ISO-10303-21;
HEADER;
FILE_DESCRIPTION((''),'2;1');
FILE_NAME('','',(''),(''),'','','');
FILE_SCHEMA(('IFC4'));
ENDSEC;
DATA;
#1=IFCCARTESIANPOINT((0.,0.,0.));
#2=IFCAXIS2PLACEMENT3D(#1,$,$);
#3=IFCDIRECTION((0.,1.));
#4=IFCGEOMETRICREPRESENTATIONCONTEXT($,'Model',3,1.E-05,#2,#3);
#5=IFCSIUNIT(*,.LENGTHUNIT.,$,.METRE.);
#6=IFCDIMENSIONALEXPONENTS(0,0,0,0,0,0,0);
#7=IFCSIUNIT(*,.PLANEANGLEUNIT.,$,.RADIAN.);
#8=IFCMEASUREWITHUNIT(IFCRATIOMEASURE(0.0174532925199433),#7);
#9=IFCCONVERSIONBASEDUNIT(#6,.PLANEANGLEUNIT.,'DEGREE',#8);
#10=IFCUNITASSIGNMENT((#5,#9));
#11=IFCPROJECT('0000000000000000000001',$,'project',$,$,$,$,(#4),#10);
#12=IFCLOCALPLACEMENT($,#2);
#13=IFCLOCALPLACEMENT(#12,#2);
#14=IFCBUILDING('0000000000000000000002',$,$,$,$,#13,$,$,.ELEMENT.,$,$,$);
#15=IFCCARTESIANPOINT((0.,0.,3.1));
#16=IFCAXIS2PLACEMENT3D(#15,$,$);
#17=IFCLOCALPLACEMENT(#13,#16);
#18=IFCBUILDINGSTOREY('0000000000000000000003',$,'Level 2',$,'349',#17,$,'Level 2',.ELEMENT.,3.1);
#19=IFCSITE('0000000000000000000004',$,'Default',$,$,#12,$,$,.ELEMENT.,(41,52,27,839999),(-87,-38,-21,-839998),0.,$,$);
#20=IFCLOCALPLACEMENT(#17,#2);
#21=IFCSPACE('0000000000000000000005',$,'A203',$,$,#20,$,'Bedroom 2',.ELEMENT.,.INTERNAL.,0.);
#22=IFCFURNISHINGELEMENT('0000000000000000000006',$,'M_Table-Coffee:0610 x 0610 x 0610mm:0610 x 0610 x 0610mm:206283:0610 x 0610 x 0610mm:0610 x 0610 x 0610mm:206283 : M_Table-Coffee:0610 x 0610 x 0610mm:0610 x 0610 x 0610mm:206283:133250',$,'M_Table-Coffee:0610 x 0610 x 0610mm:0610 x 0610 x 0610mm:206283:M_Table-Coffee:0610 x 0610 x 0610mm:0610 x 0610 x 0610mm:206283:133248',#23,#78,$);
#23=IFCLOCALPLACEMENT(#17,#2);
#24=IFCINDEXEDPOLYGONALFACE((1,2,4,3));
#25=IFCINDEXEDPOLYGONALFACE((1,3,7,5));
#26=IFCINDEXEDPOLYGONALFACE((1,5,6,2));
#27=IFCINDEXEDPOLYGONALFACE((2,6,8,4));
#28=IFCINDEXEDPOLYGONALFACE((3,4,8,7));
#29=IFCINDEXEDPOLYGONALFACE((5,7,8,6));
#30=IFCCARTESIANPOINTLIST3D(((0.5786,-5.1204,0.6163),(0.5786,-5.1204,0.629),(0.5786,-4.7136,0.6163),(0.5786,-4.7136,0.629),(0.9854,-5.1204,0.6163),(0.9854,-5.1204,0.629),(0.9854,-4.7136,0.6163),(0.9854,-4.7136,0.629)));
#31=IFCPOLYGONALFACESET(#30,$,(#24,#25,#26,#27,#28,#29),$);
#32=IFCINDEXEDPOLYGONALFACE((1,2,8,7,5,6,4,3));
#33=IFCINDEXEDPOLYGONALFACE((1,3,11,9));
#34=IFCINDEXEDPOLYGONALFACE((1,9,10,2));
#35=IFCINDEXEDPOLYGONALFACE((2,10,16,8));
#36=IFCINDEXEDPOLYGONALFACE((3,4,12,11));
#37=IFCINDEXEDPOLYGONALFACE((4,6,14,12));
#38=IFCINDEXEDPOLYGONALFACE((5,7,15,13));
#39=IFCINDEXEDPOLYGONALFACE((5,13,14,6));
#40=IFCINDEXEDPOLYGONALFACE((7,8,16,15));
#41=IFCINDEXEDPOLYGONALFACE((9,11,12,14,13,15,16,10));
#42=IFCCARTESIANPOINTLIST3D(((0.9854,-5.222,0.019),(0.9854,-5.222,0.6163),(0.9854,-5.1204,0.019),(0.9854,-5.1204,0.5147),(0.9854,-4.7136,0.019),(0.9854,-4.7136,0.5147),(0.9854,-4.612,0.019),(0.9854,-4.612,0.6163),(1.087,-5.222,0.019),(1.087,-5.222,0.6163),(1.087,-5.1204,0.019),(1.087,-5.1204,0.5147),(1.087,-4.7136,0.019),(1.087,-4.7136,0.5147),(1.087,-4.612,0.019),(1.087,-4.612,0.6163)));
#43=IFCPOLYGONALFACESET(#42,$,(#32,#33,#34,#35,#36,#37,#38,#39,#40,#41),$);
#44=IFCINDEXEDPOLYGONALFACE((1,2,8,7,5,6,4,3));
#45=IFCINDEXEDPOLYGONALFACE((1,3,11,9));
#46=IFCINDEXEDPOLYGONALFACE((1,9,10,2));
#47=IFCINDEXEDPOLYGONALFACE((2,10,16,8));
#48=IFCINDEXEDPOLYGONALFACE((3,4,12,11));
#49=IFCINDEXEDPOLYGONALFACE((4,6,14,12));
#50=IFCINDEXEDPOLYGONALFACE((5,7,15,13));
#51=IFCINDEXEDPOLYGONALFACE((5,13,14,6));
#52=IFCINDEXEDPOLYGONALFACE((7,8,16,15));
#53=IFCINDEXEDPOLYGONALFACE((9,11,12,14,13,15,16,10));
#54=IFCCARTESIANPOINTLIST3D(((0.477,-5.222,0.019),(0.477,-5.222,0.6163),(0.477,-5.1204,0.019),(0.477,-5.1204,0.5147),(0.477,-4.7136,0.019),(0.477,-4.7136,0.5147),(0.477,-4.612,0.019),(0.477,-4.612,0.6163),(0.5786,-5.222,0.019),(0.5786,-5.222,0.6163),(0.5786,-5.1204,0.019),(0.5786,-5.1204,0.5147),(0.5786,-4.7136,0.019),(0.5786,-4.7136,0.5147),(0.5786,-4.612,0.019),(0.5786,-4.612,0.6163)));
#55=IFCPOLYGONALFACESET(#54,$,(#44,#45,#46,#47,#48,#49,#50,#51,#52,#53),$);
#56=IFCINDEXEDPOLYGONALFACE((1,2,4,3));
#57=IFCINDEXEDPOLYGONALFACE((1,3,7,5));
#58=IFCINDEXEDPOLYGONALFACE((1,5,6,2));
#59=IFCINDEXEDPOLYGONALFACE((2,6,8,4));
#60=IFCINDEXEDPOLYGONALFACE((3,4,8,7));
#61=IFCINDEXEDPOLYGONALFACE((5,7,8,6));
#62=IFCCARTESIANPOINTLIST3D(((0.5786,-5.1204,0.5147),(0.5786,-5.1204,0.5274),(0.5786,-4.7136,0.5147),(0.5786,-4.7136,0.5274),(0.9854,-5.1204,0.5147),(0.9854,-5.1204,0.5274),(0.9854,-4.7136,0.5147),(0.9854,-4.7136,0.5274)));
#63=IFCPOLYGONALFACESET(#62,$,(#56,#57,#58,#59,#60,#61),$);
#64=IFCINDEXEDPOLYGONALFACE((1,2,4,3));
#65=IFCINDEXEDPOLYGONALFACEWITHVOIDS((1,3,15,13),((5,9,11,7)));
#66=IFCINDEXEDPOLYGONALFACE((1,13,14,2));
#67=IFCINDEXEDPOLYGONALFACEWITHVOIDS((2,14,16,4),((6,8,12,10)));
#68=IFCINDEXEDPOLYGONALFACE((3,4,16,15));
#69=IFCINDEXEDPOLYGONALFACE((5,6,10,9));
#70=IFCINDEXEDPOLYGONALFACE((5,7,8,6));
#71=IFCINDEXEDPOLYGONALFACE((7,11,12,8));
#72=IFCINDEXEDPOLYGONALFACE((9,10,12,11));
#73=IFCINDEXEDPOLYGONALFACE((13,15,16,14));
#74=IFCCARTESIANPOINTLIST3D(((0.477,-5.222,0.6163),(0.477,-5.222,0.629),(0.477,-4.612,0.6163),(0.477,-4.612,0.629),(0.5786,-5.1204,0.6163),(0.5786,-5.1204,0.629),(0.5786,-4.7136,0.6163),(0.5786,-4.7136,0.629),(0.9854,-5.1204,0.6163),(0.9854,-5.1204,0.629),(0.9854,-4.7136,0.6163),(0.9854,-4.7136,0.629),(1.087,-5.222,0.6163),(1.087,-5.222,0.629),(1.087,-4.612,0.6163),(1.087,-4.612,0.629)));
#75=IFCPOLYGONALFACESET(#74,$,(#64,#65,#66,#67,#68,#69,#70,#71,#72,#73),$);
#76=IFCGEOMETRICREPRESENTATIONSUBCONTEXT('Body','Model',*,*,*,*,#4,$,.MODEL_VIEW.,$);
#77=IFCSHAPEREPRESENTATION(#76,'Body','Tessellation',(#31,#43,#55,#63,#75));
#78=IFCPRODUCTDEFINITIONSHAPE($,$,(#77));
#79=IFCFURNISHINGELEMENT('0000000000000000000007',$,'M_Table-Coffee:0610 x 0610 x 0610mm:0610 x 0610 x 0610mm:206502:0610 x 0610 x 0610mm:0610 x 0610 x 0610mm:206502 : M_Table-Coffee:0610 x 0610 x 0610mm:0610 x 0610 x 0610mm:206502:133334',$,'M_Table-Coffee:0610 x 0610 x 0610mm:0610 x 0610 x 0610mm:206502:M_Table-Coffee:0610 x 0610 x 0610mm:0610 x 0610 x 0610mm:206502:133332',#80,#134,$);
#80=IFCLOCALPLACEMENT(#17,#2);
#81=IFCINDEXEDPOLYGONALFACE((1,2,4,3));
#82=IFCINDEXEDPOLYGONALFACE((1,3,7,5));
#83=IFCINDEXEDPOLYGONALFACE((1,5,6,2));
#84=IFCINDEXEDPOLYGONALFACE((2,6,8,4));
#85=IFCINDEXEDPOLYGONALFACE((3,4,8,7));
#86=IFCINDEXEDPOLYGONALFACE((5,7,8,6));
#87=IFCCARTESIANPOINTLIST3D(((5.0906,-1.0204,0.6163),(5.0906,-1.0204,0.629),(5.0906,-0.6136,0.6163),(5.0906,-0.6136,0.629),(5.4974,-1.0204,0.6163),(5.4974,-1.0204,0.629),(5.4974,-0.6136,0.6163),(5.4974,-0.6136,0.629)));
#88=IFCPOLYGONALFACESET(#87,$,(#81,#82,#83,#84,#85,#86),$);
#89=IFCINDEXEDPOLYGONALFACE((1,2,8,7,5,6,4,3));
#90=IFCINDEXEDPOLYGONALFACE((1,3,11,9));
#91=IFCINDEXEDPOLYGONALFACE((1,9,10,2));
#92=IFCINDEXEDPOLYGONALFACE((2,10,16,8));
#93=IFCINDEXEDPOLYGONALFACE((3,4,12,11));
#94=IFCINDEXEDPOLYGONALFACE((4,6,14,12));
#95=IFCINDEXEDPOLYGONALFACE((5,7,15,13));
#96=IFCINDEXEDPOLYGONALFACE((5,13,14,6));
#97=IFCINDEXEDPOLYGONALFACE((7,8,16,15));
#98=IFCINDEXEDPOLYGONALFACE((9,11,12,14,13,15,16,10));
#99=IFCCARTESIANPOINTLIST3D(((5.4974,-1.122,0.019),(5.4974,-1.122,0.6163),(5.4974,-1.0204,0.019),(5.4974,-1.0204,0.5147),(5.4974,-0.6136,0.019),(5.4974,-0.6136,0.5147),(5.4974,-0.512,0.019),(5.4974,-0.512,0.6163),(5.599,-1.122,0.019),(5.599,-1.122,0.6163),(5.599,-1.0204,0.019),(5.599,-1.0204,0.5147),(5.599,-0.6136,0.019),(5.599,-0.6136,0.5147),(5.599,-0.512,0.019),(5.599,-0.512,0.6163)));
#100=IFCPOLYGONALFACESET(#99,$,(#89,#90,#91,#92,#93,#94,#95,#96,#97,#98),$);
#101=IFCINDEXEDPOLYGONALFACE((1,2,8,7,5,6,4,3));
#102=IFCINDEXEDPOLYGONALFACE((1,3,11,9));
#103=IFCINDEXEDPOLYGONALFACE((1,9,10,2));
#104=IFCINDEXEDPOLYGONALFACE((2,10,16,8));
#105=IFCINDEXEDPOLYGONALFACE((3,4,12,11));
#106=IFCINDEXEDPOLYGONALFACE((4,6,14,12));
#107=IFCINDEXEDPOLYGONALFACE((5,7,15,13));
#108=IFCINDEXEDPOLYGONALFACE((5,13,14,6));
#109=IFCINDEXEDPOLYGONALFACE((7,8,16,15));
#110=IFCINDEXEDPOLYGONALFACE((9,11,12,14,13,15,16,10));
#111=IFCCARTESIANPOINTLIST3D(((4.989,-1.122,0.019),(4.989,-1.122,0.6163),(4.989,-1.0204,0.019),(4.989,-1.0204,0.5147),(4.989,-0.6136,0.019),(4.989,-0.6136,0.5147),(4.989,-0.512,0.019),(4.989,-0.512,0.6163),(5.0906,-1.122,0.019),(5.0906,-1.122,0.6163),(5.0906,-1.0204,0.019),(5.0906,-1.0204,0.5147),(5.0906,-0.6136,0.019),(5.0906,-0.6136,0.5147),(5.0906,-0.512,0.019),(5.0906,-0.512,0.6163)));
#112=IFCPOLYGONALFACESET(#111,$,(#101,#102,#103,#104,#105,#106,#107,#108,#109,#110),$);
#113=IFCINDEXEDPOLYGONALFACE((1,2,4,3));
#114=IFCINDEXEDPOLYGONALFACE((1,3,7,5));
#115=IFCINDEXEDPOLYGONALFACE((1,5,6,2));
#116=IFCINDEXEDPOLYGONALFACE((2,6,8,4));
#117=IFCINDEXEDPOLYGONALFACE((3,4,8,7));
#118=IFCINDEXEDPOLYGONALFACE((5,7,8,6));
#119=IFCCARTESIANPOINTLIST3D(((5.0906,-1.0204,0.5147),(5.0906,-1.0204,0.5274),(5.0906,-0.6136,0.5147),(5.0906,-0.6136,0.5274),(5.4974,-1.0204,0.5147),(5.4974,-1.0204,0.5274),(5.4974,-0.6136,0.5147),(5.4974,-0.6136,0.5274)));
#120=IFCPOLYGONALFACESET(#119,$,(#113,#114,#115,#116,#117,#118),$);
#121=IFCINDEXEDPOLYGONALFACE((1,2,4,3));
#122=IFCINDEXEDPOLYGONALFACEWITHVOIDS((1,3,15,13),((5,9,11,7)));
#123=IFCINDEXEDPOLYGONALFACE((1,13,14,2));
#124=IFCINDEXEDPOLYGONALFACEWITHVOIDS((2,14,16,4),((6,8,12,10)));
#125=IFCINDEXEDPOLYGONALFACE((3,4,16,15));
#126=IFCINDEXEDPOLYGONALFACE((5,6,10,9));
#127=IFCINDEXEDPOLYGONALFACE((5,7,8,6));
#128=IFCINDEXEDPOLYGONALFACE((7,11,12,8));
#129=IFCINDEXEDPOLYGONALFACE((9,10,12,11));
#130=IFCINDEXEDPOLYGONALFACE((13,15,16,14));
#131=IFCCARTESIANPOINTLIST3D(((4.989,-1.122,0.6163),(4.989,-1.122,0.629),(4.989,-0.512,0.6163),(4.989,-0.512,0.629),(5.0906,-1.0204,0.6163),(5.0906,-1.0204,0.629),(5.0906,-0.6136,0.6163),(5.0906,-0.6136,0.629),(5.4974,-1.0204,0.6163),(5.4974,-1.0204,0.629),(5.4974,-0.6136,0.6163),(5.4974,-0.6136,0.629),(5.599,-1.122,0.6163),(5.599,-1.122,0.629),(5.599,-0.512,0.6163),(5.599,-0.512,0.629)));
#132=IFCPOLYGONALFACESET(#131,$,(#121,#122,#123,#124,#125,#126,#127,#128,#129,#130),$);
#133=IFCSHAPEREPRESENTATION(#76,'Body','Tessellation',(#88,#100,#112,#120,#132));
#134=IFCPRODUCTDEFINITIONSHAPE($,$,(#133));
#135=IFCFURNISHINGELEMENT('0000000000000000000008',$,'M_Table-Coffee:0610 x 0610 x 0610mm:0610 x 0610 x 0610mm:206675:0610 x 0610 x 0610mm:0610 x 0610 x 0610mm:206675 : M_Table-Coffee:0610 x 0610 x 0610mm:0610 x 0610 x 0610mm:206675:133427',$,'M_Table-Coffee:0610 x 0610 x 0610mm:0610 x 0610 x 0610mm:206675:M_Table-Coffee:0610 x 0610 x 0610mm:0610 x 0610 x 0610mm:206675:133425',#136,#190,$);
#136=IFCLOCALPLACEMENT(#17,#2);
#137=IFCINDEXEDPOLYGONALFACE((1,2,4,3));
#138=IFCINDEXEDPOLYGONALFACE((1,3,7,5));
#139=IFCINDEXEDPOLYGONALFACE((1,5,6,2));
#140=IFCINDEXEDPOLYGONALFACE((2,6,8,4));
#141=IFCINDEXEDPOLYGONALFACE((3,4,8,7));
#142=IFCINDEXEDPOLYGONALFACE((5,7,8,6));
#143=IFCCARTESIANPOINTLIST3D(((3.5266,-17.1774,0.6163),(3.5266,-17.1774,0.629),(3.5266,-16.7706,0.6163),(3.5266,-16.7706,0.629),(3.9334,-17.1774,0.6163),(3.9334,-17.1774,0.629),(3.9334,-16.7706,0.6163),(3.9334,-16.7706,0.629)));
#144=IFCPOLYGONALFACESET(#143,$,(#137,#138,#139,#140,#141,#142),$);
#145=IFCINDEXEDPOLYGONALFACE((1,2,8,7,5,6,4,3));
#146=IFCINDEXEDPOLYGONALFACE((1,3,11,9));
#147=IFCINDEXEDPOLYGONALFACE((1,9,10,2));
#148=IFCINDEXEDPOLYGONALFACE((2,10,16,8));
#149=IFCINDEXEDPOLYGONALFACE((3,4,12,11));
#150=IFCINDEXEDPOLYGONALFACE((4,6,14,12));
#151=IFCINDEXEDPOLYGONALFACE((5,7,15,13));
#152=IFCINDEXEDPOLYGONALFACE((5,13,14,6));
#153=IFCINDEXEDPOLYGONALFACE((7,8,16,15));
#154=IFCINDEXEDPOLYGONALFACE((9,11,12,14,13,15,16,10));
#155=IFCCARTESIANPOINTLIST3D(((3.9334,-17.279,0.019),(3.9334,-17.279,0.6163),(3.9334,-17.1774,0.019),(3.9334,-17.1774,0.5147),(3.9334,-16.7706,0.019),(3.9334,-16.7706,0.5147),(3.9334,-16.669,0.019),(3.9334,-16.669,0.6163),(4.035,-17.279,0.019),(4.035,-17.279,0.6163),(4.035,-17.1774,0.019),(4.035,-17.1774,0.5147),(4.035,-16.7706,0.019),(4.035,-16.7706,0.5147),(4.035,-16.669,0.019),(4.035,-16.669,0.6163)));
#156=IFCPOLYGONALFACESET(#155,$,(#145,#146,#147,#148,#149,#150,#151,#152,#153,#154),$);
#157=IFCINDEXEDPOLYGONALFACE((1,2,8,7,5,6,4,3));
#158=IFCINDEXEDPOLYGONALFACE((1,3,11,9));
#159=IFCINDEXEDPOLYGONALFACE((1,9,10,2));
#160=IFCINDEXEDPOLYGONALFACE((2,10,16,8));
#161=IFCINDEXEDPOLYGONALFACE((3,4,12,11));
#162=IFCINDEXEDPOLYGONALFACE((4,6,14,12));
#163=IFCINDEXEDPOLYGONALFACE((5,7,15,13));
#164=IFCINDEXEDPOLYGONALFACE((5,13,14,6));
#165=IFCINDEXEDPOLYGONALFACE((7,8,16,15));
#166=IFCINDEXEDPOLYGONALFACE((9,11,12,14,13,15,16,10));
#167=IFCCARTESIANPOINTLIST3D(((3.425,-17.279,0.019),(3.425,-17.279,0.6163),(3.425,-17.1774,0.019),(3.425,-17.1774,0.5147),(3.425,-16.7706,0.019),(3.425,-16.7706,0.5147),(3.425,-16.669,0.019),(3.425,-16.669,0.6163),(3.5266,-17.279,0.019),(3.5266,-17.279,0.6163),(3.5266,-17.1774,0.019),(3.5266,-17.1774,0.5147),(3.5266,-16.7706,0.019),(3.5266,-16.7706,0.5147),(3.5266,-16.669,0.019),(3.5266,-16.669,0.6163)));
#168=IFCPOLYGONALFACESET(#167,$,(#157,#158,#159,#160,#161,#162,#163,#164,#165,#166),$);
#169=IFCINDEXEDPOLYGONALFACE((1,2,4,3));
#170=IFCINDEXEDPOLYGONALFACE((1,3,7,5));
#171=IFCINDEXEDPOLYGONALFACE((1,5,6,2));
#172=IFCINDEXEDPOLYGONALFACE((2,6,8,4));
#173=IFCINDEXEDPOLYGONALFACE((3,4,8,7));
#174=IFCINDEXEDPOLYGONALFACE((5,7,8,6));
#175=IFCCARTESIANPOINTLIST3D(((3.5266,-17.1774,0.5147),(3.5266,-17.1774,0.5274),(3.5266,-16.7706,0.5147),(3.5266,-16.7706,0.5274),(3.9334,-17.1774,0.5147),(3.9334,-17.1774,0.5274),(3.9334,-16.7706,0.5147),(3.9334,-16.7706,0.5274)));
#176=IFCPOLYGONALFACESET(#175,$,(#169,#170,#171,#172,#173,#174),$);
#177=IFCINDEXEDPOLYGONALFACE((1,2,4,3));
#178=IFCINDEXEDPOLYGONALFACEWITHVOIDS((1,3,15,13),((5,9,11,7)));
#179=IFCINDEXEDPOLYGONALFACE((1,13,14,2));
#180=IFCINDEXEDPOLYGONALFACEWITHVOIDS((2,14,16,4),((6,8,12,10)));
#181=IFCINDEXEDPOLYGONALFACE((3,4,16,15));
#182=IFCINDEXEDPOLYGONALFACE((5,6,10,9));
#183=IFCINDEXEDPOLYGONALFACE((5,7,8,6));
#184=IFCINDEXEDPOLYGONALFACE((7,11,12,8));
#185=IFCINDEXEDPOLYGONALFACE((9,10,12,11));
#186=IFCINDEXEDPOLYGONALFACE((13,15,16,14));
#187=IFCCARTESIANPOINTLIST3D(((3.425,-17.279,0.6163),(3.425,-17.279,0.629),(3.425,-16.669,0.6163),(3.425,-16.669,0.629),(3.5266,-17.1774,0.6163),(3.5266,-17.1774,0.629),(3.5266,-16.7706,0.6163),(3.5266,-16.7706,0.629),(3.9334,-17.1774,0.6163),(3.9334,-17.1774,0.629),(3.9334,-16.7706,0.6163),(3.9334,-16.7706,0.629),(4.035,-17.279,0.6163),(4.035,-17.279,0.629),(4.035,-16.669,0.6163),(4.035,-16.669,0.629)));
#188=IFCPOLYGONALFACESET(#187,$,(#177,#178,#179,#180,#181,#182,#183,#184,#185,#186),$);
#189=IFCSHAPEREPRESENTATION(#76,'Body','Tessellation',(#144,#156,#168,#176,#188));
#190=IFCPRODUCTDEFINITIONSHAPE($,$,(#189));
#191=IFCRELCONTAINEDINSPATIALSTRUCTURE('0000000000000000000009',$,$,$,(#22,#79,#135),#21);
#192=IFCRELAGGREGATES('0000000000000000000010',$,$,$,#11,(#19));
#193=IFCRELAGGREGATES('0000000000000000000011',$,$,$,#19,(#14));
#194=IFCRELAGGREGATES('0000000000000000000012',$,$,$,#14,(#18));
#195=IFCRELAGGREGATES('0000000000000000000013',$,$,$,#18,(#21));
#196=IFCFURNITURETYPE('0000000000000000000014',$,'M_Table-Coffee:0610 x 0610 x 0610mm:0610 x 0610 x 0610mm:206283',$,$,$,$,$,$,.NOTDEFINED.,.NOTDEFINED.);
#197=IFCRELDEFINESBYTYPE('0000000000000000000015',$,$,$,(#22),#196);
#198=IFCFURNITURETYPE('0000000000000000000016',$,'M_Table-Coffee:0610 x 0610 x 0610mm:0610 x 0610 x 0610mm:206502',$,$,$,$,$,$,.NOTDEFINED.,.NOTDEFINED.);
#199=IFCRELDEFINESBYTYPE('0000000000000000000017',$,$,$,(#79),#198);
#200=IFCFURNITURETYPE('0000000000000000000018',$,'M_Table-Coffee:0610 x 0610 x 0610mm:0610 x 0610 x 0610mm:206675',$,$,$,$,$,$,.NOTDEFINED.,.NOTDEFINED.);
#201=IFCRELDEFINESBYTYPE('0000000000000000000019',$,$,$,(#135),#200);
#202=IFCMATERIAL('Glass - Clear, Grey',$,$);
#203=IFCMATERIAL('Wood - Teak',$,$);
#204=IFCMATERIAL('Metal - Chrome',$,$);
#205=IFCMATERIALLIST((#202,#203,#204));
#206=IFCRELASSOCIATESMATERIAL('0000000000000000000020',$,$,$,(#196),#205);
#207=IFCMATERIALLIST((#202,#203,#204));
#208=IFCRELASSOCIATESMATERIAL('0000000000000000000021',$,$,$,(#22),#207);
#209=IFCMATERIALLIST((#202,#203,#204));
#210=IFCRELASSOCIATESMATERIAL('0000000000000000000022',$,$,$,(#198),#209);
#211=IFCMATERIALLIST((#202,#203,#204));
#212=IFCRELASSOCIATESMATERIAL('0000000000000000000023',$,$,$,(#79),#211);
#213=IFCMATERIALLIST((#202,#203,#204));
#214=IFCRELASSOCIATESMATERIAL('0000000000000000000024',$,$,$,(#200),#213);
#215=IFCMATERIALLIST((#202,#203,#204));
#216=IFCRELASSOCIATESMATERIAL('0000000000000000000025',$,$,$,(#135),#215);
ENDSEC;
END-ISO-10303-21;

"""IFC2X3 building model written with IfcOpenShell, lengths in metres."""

from ifc_helpers import new_model, entity, si_unit, converted_unit, direction, frame, frame_2d, origin, origin_2d_with_axis, place, context, subcontext, project, spatial, polyline, rectangle, outline, extrude, source, transform, mapped, material, material_list, type_object, type_shapes, element, save


model = new_model("IFC2X3")

# Units and contexts
model_context = context("Model", 3, precision=1e-05, world=origin(), true_north=direction((0.0, 1.0)))
body_context = subcontext(model_context, "Body", "Model", "MODEL_VIEW")
ifc_project = project(units=[si_unit("LENGTHUNIT", "METRE"), converted_unit("PLANEANGLEUNIT", "DEGREE", entity("IfcRatioMeasure", 0.0174532925199433), si_unit("PLANEANGLEUNIT", "RADIAN"), dimensions=[0, 0, 0, 0, 0, 0, 0])], contexts=[model_context])

# Site, building, storey
site_placement = place(None, origin())
site = spatial("IfcSite", under=ifc_project, at=site_placement, Name="Default", CompositionType="ELEMENT", RefLatitude=(41, 52, 27, 839999), RefLongitude=(-87, -38, -21, -839998), RefElevation=0.0)
building_placement = place(site_placement, origin())
building = spatial("IfcBuilding", under=site, at=building_placement, CompositionType="ELEMENT")
storey_placement = place(building_placement, frame((0.0, 0.0, 3.1)))
storey = spatial("IfcBuildingStorey", under=building, at=storey_placement, Name="Level 2", ObjectType="349", LongName="Level 2", CompositionType="ELEMENT", Elevation=3.1)

# Shared definitions
space_placement = place(storey_placement, origin())
space = spatial("IfcSpace", under=storey, at=space_placement, Name="A203", LongName="Bedroom 2", CompositionType="ELEMENT", InteriorOrExteriorSpace="INTERNAL", ElevationWithFlooring=0.0)

# Furnishing elements
ifc_material_1 = material(Name="Glass - Clear, Grey")
ifc_material_2 = material(Name="Wood - Teak")
ifc_material_3 = material(Name="Metal - Chrome")
ifc_material_list_1 = material_list([ifc_material_1, ifc_material_2, ifc_material_3])
ifc_material_list_2 = material_list([ifc_material_1, ifc_material_2, ifc_material_3])
furniture_type_1 = type_object("IfcFurnitureType", Name="M_Table-Coffee:0610 x 0610 x 0610mm:0610 x 0610 x 0610mm:206283", material=ifc_material_list_2)
shared_shape_1 = source(origin(), body_context, "Body", "SweptSolid", [
    extrude(rectangle(XDim=0.4068, YDim=0.4068, at=frame_2d((0.0, 0.0), x_axis=(1.0, 0.0))), frame((0.782, -4.917, 3.7163), z_axis=(0.0, 0.0, 1.0), x_axis=(0.0, -1.0, 0.0)), (0.0, 0.0, 1.0), 0.0127),
    extrude(outline(polyline([(-0.305, -0.324), (0.305, -0.324), (0.305, 0.2732), (0.2034, 0.2732), (0.2034, -0.2225), (-0.2034, -0.2225), (-0.2034, 0.2732), (-0.305, 0.2732), (-0.305, -0.324)])), frame((0.9854, -4.917, 3.3923), z_axis=(1.0, 0.0, 0.0), x_axis=(0.0, -1.0, 0.0)), (0.0, 0.0, 1.0), 0.1016),
    extrude(outline(polyline([(-0.3241, -0.305), (0.2733, -0.305), (0.2733, -0.2034), (-0.2224, -0.2034), (-0.2224, 0.2034), (0.2733, 0.2034), (0.2733, 0.305), (-0.3241, 0.305), (-0.3241, -0.305)])), frame((0.477, -4.917, 3.3923), z_axis=(1.0, 0.0, 0.0), x_axis=(0.0, 0.0, -1.0)), (0.0, 0.0, 1.0), 0.1016),
    extrude(rectangle(XDim=0.4068, YDim=0.4068, at=frame_2d((0.0, 0.0), x_axis=(1.0, 0.0))), frame((0.782, -4.917, 3.6147), z_axis=(0.0, 0.0, 1.0), x_axis=(0.0, -1.0, 0.0)), (0.0, 0.0, 1.0), 0.0127),
    extrude(outline(polyline([(-0.305, -0.305), (0.305, -0.305), (0.305, 0.305), (-0.305, 0.305), (-0.305, -0.305)]), holes=[polyline([(0.2034, 0.2034), (0.2034, -0.2034), (-0.2034, -0.2034), (-0.2034, 0.2034), (0.2034, 0.2034)])]), frame((0.782, -4.917, 3.7163), z_axis=(0.0, 0.0, 1.0), x_axis=(0.0, -1.0, 0.0)), (0.0, 0.0, 1.0), 0.0127),
])
type_shapes(furniture_type_1, [shared_shape_1])
furnishing_1_placement = place(space_placement, frame((0.0, 0.0, -3.1)))
element("IfcFurnishingElement", 1, at=furnishing_1_placement, inside=space, type_object=furniture_type_1, material=ifc_material_list_1, Name="M_Table-Coffee:0610 x 0610 x 0610mm:0610 x 0610 x 0610mm:206283:0610 x 0610 x 0610mm:0610 x 0610 x 0610mm:206283 : M_Table-Coffee:0610 x 0610 x 0610mm:0610 x 0610 x 0610mm:206283:133250", ObjectType="M_Table-Coffee:0610 x 0610 x 0610mm:0610 x 0610 x 0610mm:206283:M_Table-Coffee:0610 x 0610 x 0610mm:0610 x 0610 x 0610mm:206283:133248", context=body_context, shape_type="MappedRepresentation", body=[
    mapped(shared_shape_1, transform((0.0, 0.0, 0.0), scale=1.0)),
])
ifc_material_list_3 = material_list([ifc_material_1, ifc_material_2, ifc_material_3])
ifc_material_list_4 = material_list([ifc_material_1, ifc_material_2, ifc_material_3])
furniture_type_2 = type_object("IfcFurnitureType", Name="M_Table-Coffee:0610 x 0610 x 0610mm:0610 x 0610 x 0610mm:206502", material=ifc_material_list_4)
shared_shape_2 = source(origin(), body_context, "Body", "SweptSolid", [
    extrude(rectangle(XDim=0.4068, YDim=0.4068, at=frame_2d((0.0, 0.0), x_axis=(1.0, 0.0))), frame((5.294, -0.817, 3.7163), z_axis=(0.0, 0.0, 1.0), x_axis=(0.0, -1.0, 0.0)), (0.0, 0.0, 1.0), 0.0127),
    extrude(outline(polyline([(-0.305, -0.324), (0.305, -0.324), (0.305, 0.2732), (0.2034, 0.2732), (0.2034, -0.2225), (-0.2034, -0.2225), (-0.2034, 0.2732), (-0.305, 0.2732), (-0.305, -0.324)])), frame((5.4974, -0.817, 3.3923), z_axis=(1.0, 0.0, 0.0), x_axis=(0.0, -1.0, 0.0)), (0.0, 0.0, 1.0), 0.1016),
    extrude(outline(polyline([(-0.3241, -0.305), (0.2733, -0.305), (0.2733, -0.2034), (-0.2224, -0.2034), (-0.2224, 0.2034), (0.2733, 0.2034), (0.2733, 0.305), (-0.3241, 0.305), (-0.3241, -0.305)])), frame((4.989, -0.817, 3.3923), z_axis=(1.0, 0.0, 0.0), x_axis=(0.0, 0.0, -1.0)), (0.0, 0.0, 1.0), 0.1016),
    extrude(rectangle(XDim=0.4068, YDim=0.4068, at=origin_2d_with_axis()), frame((5.294, -0.817, 3.6147), z_axis=(0.0, 0.0, 1.0), x_axis=(0.0, -1.0, 0.0)), (0.0, 0.0, 1.0), 0.0127),
    extrude(outline(polyline([(-0.305, -0.305), (0.305, -0.305), (0.305, 0.305), (-0.305, 0.305), (-0.305, -0.305)]), holes=[polyline([(0.2034, 0.2034), (0.2034, -0.2034), (-0.2034, -0.2034), (-0.2034, 0.2034), (0.2034, 0.2034)])]), frame((5.294, -0.817, 3.7163), z_axis=(0.0, 0.0, 1.0), x_axis=(0.0, -1.0, 0.0)), (0.0, 0.0, 1.0), 0.0127),
])
type_shapes(furniture_type_2, [shared_shape_2])
furnishing_2_placement = place(space_placement, frame((0.0, 0.0, -3.1)))
element("IfcFurnishingElement", 2, at=furnishing_2_placement, inside=space, type_object=furniture_type_2, material=ifc_material_list_3, Name="M_Table-Coffee:0610 x 0610 x 0610mm:0610 x 0610 x 0610mm:206502:0610 x 0610 x 0610mm:0610 x 0610 x 0610mm:206502 : M_Table-Coffee:0610 x 0610 x 0610mm:0610 x 0610 x 0610mm:206502:133334", ObjectType="M_Table-Coffee:0610 x 0610 x 0610mm:0610 x 0610 x 0610mm:206502:M_Table-Coffee:0610 x 0610 x 0610mm:0610 x 0610 x 0610mm:206502:133332", context=body_context, shape_type="MappedRepresentation", body=[
    mapped(shared_shape_2, transform((0.0, 0.0, 0.0), scale=1.0)),
])
ifc_material_list_5 = material_list([ifc_material_1, ifc_material_2, ifc_material_3])
ifc_material_list_6 = material_list([ifc_material_1, ifc_material_2, ifc_material_3])
furniture_type_3 = type_object("IfcFurnitureType", Name="M_Table-Coffee:0610 x 0610 x 0610mm:0610 x 0610 x 0610mm:206675", material=ifc_material_list_6)
shared_shape_3 = source(origin(), body_context, "Body", "SweptSolid", [
    extrude(rectangle(XDim=0.4068, YDim=0.4068, at=frame_2d((0.0, 0.0), x_axis=(1.0, 0.0))), frame((3.73, -16.974, 3.7163), z_axis=(0.0, 0.0, 1.0), x_axis=(0.0, -1.0, 0.0)), (0.0, 0.0, 1.0), 0.0127),
    extrude(outline(polyline([(-0.305, -0.324), (0.305, -0.324), (0.305, 0.2732), (0.2034, 0.2732), (0.2034, -0.2225), (-0.2034, -0.2225), (-0.2034, 0.2732), (-0.305, 0.2732), (-0.305, -0.324)])), frame((3.9334, -16.974, 3.3923), z_axis=(1.0, 0.0, 0.0), x_axis=(0.0, -1.0, 0.0)), (0.0, 0.0, 1.0), 0.1016),
    extrude(outline(polyline([(-0.3241, -0.305), (0.2733, -0.305), (0.2733, -0.2034), (-0.2224, -0.2034), (-0.2224, 0.2034), (0.2733, 0.2034), (0.2733, 0.305), (-0.3241, 0.305), (-0.3241, -0.305)])), frame((3.425, -16.974, 3.3923), z_axis=(1.0, 0.0, 0.0), x_axis=(0.0, 0.0, -1.0)), (0.0, 0.0, 1.0), 0.1016),
    extrude(rectangle(XDim=0.4068, YDim=0.4068, at=frame_2d((0.0, 0.0), x_axis=(1.0, 0.0))), frame((3.73, -16.974, 3.6147), z_axis=(0.0, 0.0, 1.0), x_axis=(0.0, -1.0, 0.0)), (0.0, 0.0, 1.0), 0.0127),
    extrude(outline(polyline([(-0.305, -0.305), (0.305, -0.305), (0.305, 0.305), (-0.305, 0.305), (-0.305, -0.305)]), holes=[polyline([(0.2034, 0.2034), (0.2034, -0.2034), (-0.2034, -0.2034), (-0.2034, 0.2034), (0.2034, 0.2034)])]), frame((3.73, -16.974, 3.7163), z_axis=(0.0, 0.0, 1.0), x_axis=(0.0, -1.0, 0.0)), (0.0, 0.0, 1.0), 0.0127),
])
type_shapes(furniture_type_3, [shared_shape_3])
furnishing_3_placement = place(space_placement, frame((0.0, 0.0, -3.1)))
element("IfcFurnishingElement", 3, at=furnishing_3_placement, inside=space, type_object=furniture_type_3, material=ifc_material_list_5, Name="M_Table-Coffee:0610 x 0610 x 0610mm:0610 x 0610 x 0610mm:206675:0610 x 0610 x 0610mm:0610 x 0610 x 0610mm:206675 : M_Table-Coffee:0610 x 0610 x 0610mm:0610 x 0610 x 0610mm:206675:133427", ObjectType="M_Table-Coffee:0610 x 0610 x 0610mm:0610 x 0610 x 0610mm:206675:M_Table-Coffee:0610 x 0610 x 0610mm:0610 x 0610 x 0610mm:206675:133425", context=body_context, shape_type="MappedRepresentation", body=[
    mapped(shared_shape_3, transform((0.0, 0.0, 0.0), scale=1.0)),
])

save(model, "model.ifc")
